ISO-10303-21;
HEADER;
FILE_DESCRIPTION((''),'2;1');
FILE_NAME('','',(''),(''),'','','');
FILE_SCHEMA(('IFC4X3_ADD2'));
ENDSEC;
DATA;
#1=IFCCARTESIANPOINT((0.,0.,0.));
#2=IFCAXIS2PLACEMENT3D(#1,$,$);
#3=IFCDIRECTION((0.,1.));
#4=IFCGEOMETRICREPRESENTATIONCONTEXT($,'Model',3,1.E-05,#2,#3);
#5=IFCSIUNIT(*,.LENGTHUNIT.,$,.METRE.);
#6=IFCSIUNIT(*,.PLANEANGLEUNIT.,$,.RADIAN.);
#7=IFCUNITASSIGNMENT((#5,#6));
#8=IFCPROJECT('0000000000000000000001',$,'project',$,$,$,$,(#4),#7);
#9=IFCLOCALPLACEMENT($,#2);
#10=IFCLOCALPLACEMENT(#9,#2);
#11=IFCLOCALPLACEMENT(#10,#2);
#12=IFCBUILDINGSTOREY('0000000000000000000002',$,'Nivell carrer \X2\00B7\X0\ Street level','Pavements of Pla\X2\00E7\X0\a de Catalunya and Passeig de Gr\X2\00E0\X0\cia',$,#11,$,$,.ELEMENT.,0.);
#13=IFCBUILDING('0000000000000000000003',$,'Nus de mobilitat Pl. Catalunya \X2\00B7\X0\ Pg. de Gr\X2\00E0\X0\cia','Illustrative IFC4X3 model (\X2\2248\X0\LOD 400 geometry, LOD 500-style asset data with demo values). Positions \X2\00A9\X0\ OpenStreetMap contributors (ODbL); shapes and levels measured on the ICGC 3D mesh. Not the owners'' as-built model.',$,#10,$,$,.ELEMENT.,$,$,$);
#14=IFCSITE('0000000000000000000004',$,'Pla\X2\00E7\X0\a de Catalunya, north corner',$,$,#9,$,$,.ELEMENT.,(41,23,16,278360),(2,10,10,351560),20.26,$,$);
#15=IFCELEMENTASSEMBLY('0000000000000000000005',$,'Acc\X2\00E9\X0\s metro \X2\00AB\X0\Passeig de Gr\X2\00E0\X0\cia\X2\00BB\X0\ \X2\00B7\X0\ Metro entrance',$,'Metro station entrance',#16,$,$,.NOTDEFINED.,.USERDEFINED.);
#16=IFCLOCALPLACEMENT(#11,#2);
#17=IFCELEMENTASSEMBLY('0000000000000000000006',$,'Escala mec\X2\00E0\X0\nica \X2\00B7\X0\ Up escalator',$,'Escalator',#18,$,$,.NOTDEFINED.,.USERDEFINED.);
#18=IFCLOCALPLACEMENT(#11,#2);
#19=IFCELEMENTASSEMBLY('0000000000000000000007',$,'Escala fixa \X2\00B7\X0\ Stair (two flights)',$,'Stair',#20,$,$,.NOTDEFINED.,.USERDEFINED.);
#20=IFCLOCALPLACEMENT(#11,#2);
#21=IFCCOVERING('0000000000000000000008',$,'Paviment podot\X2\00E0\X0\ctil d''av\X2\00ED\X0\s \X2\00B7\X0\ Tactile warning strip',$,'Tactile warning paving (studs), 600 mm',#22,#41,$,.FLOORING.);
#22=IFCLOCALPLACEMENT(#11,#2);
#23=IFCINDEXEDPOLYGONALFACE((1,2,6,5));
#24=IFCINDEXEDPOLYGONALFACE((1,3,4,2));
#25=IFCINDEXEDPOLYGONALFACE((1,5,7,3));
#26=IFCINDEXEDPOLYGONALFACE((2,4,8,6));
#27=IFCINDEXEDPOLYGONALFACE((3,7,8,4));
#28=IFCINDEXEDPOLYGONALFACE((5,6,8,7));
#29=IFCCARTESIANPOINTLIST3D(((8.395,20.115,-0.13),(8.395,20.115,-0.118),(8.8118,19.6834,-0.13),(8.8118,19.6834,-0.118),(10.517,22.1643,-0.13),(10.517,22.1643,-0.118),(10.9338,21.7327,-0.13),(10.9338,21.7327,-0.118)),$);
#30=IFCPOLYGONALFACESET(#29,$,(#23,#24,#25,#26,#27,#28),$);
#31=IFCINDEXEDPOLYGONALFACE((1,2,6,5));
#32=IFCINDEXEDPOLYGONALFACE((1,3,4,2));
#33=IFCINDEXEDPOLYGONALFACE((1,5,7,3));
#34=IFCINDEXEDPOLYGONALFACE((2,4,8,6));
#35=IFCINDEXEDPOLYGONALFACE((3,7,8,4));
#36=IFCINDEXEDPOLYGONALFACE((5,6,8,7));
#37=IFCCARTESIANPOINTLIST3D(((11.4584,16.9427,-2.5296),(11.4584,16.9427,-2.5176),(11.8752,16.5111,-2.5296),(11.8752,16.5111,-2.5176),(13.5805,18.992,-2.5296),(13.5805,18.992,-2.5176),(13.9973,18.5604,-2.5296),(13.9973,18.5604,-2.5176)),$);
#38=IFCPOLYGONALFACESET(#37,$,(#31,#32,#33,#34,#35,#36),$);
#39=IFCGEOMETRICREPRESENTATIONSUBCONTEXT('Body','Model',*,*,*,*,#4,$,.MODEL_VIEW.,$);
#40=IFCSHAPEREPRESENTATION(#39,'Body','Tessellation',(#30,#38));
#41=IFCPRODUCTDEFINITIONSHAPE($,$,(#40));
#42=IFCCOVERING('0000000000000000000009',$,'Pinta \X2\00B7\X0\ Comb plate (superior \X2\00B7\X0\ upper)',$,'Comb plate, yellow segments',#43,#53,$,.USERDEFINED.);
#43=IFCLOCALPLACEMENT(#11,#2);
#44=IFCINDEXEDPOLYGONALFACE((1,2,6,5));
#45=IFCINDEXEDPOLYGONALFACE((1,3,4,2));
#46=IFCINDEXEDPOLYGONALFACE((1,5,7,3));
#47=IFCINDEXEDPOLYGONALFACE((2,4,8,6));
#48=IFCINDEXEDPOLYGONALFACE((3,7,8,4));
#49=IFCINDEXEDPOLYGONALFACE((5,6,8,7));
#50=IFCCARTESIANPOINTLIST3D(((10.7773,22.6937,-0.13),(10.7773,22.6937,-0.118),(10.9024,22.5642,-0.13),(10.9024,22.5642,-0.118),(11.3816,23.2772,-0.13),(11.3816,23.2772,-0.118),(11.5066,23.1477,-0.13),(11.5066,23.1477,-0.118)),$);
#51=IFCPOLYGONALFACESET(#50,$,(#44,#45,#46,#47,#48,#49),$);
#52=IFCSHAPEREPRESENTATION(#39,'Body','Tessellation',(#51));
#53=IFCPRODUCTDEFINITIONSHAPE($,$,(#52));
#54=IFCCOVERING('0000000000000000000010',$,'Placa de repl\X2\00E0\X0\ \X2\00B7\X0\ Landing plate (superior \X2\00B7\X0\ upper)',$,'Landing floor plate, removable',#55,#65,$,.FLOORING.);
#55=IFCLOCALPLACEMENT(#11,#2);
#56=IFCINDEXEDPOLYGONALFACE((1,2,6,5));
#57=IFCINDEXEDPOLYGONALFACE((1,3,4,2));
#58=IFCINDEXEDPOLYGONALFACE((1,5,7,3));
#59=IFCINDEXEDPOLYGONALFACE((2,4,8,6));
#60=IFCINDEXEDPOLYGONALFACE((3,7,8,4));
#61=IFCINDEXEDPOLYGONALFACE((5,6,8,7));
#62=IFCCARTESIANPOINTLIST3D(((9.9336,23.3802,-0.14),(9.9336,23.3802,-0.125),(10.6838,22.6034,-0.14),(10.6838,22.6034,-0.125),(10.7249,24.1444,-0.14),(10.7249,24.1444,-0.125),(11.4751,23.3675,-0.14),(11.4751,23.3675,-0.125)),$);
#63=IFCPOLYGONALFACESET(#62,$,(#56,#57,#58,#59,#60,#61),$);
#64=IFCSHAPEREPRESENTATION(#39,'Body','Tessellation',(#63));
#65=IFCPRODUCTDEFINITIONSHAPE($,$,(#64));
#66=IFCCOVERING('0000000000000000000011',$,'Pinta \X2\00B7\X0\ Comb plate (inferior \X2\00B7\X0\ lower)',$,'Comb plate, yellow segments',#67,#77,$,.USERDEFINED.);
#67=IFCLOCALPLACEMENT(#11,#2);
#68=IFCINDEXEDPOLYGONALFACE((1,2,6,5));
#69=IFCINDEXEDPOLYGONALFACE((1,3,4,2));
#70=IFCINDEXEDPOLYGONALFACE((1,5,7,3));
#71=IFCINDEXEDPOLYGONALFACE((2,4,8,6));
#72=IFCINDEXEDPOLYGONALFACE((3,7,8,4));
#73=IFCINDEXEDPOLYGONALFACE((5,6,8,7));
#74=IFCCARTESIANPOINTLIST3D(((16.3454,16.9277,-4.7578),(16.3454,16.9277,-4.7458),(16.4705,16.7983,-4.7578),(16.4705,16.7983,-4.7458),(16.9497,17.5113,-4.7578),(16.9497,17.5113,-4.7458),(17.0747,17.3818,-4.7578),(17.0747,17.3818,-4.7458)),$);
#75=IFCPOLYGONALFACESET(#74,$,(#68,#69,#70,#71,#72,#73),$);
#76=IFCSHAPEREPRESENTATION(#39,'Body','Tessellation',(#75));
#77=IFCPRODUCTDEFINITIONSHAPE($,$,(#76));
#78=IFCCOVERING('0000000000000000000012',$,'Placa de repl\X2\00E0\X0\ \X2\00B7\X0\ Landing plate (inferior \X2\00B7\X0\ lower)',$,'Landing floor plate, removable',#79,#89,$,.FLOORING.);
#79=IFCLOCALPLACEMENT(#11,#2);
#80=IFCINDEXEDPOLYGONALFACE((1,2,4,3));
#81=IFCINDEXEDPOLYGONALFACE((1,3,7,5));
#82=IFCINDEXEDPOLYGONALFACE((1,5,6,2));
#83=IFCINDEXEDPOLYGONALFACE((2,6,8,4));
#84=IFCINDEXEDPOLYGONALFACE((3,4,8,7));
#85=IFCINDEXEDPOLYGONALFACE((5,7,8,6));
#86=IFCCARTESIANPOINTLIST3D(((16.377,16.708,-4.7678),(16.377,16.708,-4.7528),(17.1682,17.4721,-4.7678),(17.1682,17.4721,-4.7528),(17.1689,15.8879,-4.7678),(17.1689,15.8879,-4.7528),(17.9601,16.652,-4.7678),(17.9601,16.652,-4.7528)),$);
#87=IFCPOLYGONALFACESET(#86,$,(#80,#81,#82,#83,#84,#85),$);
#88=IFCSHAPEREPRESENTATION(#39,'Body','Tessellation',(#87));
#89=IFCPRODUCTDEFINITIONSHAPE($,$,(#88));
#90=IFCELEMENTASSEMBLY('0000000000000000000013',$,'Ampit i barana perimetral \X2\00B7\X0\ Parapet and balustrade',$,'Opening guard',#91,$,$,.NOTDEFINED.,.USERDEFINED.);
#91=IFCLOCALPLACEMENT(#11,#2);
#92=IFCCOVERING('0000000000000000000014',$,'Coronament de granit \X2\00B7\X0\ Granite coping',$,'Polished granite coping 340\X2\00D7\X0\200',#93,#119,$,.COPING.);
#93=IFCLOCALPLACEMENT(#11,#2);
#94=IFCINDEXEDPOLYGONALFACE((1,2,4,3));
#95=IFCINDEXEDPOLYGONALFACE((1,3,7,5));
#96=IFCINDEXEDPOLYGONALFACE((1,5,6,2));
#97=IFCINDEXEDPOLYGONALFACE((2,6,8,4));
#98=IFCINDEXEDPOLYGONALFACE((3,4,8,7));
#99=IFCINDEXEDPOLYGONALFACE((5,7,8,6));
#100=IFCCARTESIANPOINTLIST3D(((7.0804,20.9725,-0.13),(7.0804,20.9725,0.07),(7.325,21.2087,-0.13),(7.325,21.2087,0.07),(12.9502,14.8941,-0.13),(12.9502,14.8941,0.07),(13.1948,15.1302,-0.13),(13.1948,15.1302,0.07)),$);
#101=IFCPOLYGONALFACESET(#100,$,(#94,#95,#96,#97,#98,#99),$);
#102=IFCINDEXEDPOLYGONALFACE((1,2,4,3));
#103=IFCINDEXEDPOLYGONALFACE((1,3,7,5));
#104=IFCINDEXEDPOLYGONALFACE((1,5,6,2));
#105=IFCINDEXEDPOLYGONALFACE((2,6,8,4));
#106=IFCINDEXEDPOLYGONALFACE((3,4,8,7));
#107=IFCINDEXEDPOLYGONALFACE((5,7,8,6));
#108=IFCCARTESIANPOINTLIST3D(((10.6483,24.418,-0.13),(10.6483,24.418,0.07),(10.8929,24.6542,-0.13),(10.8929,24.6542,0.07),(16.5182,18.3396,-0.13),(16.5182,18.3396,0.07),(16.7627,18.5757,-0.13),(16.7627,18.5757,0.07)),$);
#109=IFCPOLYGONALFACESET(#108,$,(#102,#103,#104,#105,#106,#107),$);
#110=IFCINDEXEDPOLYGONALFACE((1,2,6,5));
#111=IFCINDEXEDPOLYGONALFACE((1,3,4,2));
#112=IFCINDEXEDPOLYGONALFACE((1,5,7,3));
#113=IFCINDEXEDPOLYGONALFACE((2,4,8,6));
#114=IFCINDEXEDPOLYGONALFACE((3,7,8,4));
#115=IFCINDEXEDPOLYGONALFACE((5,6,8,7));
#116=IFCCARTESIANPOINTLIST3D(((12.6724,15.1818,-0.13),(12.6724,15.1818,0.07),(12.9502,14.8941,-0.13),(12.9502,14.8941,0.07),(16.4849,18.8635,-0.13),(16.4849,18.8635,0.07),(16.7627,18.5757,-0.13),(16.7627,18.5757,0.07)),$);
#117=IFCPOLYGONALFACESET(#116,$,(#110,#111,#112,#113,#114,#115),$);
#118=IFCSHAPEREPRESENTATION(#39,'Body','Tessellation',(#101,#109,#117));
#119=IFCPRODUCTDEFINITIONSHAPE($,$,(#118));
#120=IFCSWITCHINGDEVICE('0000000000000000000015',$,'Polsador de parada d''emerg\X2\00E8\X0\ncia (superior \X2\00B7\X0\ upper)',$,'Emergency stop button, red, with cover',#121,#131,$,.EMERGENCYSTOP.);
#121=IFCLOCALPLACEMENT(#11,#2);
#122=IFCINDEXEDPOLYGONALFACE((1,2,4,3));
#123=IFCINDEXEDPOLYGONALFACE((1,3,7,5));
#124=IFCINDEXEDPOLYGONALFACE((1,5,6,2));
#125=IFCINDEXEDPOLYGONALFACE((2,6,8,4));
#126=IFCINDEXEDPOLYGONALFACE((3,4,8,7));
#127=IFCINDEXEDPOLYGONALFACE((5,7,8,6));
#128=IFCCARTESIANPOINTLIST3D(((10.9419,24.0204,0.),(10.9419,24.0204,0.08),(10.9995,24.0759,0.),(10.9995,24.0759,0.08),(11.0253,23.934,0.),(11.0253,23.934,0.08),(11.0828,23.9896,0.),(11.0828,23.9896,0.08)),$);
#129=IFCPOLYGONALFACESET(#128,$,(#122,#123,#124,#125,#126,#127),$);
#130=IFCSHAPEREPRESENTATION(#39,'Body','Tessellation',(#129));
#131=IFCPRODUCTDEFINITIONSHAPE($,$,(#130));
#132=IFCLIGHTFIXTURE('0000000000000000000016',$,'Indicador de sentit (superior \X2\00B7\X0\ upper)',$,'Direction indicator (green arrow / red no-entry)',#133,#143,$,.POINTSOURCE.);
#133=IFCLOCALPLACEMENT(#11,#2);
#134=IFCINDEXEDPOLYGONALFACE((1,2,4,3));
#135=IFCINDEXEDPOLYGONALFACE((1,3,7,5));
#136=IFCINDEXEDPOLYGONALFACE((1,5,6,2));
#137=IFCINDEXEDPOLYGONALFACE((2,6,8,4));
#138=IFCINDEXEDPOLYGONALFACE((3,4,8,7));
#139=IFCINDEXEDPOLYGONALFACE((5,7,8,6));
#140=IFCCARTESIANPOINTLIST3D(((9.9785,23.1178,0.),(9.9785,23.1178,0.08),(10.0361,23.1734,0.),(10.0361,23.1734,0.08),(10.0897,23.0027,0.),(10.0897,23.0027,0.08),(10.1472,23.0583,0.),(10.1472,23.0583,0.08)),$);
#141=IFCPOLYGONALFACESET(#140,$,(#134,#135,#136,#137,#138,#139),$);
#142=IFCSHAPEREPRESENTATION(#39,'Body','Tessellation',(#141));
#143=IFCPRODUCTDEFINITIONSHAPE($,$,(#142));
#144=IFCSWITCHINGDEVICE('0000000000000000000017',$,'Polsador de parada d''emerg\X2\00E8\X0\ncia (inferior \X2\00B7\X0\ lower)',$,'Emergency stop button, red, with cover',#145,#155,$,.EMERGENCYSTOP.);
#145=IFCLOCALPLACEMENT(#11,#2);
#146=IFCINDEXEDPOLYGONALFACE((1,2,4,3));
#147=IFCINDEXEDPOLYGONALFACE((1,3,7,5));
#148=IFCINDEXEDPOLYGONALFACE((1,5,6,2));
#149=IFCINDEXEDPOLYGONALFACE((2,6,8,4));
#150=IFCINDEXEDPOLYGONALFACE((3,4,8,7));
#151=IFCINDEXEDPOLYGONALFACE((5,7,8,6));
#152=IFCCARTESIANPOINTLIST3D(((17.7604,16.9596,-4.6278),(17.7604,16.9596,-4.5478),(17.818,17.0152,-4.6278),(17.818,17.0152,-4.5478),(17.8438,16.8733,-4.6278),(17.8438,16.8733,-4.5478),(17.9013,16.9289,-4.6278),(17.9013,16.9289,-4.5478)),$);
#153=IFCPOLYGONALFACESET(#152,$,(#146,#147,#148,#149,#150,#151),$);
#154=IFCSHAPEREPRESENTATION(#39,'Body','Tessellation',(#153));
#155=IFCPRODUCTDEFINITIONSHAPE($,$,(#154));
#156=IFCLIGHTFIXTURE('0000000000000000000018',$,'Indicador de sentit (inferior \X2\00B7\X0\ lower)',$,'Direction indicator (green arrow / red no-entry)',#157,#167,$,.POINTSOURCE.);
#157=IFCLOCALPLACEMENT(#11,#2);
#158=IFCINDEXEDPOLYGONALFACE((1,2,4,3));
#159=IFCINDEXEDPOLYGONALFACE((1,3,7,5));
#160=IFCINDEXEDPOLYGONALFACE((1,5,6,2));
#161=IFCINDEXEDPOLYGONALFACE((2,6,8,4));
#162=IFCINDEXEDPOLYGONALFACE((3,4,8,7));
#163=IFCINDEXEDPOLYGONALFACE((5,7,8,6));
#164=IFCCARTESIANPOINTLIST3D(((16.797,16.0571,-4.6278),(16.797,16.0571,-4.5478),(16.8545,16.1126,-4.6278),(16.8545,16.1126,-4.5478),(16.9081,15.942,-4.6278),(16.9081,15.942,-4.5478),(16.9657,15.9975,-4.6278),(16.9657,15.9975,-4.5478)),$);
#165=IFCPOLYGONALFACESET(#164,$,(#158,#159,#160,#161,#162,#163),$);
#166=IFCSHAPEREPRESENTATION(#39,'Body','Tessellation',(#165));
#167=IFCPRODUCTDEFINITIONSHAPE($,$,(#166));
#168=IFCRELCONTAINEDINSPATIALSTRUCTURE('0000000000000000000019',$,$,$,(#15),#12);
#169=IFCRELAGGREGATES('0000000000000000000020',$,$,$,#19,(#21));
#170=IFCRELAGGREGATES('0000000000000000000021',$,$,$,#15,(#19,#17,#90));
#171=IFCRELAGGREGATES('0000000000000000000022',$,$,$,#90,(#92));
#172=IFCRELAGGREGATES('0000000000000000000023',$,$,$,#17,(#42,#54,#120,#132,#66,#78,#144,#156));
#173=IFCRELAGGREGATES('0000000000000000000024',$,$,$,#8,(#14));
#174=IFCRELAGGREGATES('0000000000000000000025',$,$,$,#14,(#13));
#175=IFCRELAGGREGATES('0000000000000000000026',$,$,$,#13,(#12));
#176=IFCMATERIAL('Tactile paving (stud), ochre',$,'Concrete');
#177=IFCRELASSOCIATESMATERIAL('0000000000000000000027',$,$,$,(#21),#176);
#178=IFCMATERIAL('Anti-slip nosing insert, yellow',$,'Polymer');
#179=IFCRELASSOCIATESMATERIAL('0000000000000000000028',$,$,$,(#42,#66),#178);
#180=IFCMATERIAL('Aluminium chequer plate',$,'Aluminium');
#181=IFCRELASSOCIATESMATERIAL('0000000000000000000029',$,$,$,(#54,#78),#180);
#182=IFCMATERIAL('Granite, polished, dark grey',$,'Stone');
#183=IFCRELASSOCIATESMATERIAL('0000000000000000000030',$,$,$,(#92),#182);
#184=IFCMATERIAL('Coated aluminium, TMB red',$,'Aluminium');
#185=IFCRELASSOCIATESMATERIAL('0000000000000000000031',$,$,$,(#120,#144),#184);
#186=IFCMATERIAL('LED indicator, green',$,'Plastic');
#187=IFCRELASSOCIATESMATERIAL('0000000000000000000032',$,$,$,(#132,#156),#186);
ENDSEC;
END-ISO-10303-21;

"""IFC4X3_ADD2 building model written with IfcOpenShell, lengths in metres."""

from ifc_helpers import new_model, si_unit, direction, frame, frame_2d, origin, place, context, subcontext, project, spatial, rectangle, extrude, material, element, aggregate, save


model = new_model("IFC4X3_ADD2")

# Units and contexts
model_context = context("Model", 3, precision=1e-05, world=origin(), true_north=direction((0.0, 1.0)))
body_context = subcontext(model_context, "Body", "Model", "MODEL_VIEW")
ifc_project = project(units=[si_unit("LENGTHUNIT", "METRE"), si_unit("PLANEANGLEUNIT", "RADIAN")], contexts=[model_context])

# Site, building, storey
site_placement = place(None, origin())
site = spatial("IfcSite", under=ifc_project, at=site_placement, Name="Plaça de Catalunya, north corner", CompositionType="ELEMENT", RefLatitude=(41, 23, 16, 278360), RefLongitude=(2, 10, 10, 351560), RefElevation=20.26)
building_placement = place(site_placement, origin())
building = spatial("IfcBuilding", under=site, at=building_placement, Name="Nus de mobilitat Pl. Catalunya · Pg. de Gràcia", Description="Illustrative IFC4X3 model (≈LOD 400 geometry, LOD 500-style asset data with demo values). Positions © OpenStreetMap contributors (ODbL); shapes and levels measured on the ICGC 3D mesh. Not the owners' as-built model.", CompositionType="ELEMENT")
storey_placement = place(building_placement, origin())
storey = spatial("IfcBuildingStorey", under=building, at=storey_placement, Name="Nivell carrer · Street level", Description="Pavements of Plaça de Catalunya and Passeig de Gràcia", CompositionType="ELEMENT", Elevation=0.0)

# Element assemblies, coverings, switching devices, light fixtures
assembly_1_placement = place(building_placement, origin())
assembly_1 = element("IfcElementAssembly", 1, at=assembly_1_placement, inside=storey, Name="Accés metro «Passeig de Gràcia» · Metro entrance", ObjectType="Metro station entrance", AssemblyPlace="NOTDEFINED", PredefinedType="USERDEFINED")
assembly_2_placement = place(building_placement, origin())
assembly_2 = element("IfcElementAssembly", 2, at=assembly_2_placement, Name="Escala mecànica · Up escalator", ObjectType="Escalator", AssemblyPlace="NOTDEFINED", PredefinedType="USERDEFINED")
assembly_3_placement = place(building_placement, origin())
assembly_3 = element("IfcElementAssembly", 3, at=assembly_3_placement, Name="Escala fixa · Stair (two flights)", ObjectType="Stair", AssemblyPlace="NOTDEFINED", PredefinedType="USERDEFINED")
ifc_material_1 = material(Name="Anti-slip nosing insert, yellow", Category="Polymer")
ifc_material_2 = material(Name="Tactile paving (stud), ochre", Category="Concrete")
covering_1_placement = place(building_placement, origin())
covering_1 = element("IfcCovering", 4, at=covering_1_placement, material=ifc_material_2, Name="Paviment podotàctil d'avís · Tactile warning strip", ObjectType="Tactile warning paving (studs), 600 mm", PredefinedType="FLOORING", context=body_context, shape_type="SweptSolid", body=[
    extrude(rectangle(XDim=0.6, YDim=2.95, at=frame_2d((0.0, 0.0), x_axis=(0.694658, -0.71934))), frame((9.6644, 20.9238, -0.13)), (0.0, 0.0, 1.0), 0.012),
    extrude(rectangle(XDim=0.6, YDim=2.95, at=frame_2d((0.0, 0.0), x_axis=(0.694658, -0.71934))), frame((12.7278, 17.7516, -2.5296)), (0.0, 0.0, 1.0), 0.012),
])
aggregate(assembly_3, [covering_1])
covering_2_placement = place(building_placement, origin())
covering_2 = element("IfcCovering", 5, at=covering_2_placement, material=ifc_material_1, Name="Pinta · Comb plate (superior · upper)", ObjectType="Comb plate, yellow segments", PredefinedType="USERDEFINED", context=body_context, shape_type="SweptSolid", body=[
    extrude(rectangle(XDim=0.18, YDim=0.84, at=frame_2d((0.0, 0.0), x_axis=(0.694658, -0.71934))), frame((11.142, 22.9207, -0.13)), (0.0, 0.0, 1.0), 0.012),
])
ifc_material_3 = material(Name="Aluminium chequer plate", Category="Aluminium")
covering_3_placement = place(building_placement, origin())
covering_3 = element("IfcCovering", 6, at=covering_3_placement, material=ifc_material_3, Name="Placa de replà · Landing plate (superior · upper)", ObjectType="Landing floor plate, removable", PredefinedType="FLOORING", context=body_context, shape_type="SweptSolid", body=[
    extrude(rectangle(XDim=1.08, YDim=1.1, at=frame_2d((0.0, 0.0), x_axis=(0.694658, -0.71934))), frame((10.7043, 23.3739, -0.14)), (0.0, 0.0, 1.0), 0.015),
])
covering_4_placement = place(building_placement, origin())
covering_4 = element("IfcCovering", 7, at=covering_4_placement, material=ifc_material_1, Name="Pinta · Comb plate (inferior · lower)", ObjectType="Comb plate, yellow segments", PredefinedType="USERDEFINED", context=body_context, shape_type="SweptSolid", body=[
    extrude(rectangle(XDim=0.18, YDim=0.84, at=frame_2d((0.0, 0.0), x_axis=(0.694658, -0.71934))), frame((16.7101, 17.1548, -4.7578)), (0.0, 0.0, 1.0), 0.012),
])
covering_5_placement = place(building_placement, origin())
covering_5 = element("IfcCovering", 8, at=covering_5_placement, material=ifc_material_3, Name="Placa de replà · Landing plate (inferior · lower)", ObjectType="Landing floor plate, removable", PredefinedType="FLOORING", context=body_context, shape_type="SweptSolid", body=[
    extrude(rectangle(XDim=1.14, YDim=1.1, at=frame_2d((0.0, 0.0), x_axis=(0.694658, -0.71934))), frame((17.1685, 16.68, -4.7678)), (0.0, 0.0, 1.0), 0.015),
])
assembly_4_placement = place(building_placement, origin())
assembly_4 = element("IfcElementAssembly", 9, at=assembly_4_placement, Name="Ampit i barana perimetral · Parapet and balustrade", ObjectType="Opening guard", AssemblyPlace="NOTDEFINED", PredefinedType="USERDEFINED")
aggregate(assembly_1, [assembly_3, assembly_2, assembly_4])
ifc_material_4 = material(Name="Granite, polished, dark grey", Category="Stone")
covering_6_placement = place(building_placement, origin())
covering_6 = element("IfcCovering", 10, at=covering_6_placement, material=ifc_material_4, Name="Coronament de granit · Granite coping", ObjectType="Polished granite coping 340×200", PredefinedType="COPING", context=body_context, shape_type="SweptSolid", body=[
    extrude(rectangle(XDim=8.45, YDim=0.34, at=frame_2d((0.0, 0.0), x_axis=(0.694658, -0.71934))), frame((10.1376, 18.0514, -0.13)), (0.0, 0.0, 1.0), 0.2),
    extrude(rectangle(XDim=8.45, YDim=0.34, at=frame_2d((0.0, 0.0), x_axis=(0.694658, -0.71934))), frame((13.7055, 21.4969, -0.13)), (0.0, 0.0, 1.0), 0.2),
    extrude(rectangle(XDim=0.4, YDim=5.3, at=frame_2d((0.0, 0.0), x_axis=(0.694658, -0.71934))), frame((14.7176, 16.8788, -0.13)), (0.0, 0.0, 1.0), 0.2),
])
aggregate(assembly_4, [covering_6])
ifc_material_5 = material(Name="Coated aluminium, TMB red", Category="Aluminium")
switching_device_1_placement = place(building_placement, origin())
switching_device_1 = element("IfcSwitchingDevice", 11, at=switching_device_1_placement, material=ifc_material_5, Name="Polsador de parada d'emergència (superior · upper)", ObjectType="Emergency stop button, red, with cover", PredefinedType="EMERGENCYSTOP", context=body_context, shape_type="SweptSolid", body=[
    extrude(rectangle(XDim=0.12, YDim=0.08, at=frame_2d((0.0, 0.0), x_axis=(0.694658, -0.71934))), frame((11.0124, 24.005, 0.0)), (0.0, 0.0, 1.0), 0.08),
])
ifc_material_6 = material(Name="LED indicator, green", Category="Plastic")
light_fixture_1_placement = place(building_placement, origin())
light_fixture_1 = element("IfcLightFixture", 12, at=light_fixture_1_placement, material=ifc_material_6, Name="Indicador de sentit (superior · upper)", ObjectType="Direction indicator (green arrow / red no-entry)", PredefinedType="POINTSOURCE", context=body_context, shape_type="SweptSolid", body=[
    extrude(rectangle(XDim=0.16, YDim=0.08, at=frame_2d((0.0, 0.0), x_axis=(0.694658, -0.71934))), frame((10.0629, 23.088, 0.0)), (0.0, 0.0, 1.0), 0.08),
])
switching_device_2_placement = place(building_placement, origin())
switching_device_2 = element("IfcSwitchingDevice", 13, at=switching_device_2_placement, material=ifc_material_5, Name="Polsador de parada d'emergència (inferior · lower)", ObjectType="Emergency stop button, red, with cover", PredefinedType="EMERGENCYSTOP", context=body_context, shape_type="SweptSolid", body=[
    extrude(rectangle(XDim=0.12, YDim=0.08, at=frame_2d((0.0, 0.0), x_axis=(0.694658, -0.71934))), frame((17.8309, 16.9442, -4.6278)), (0.0, 0.0, 1.0), 0.08),
])
light_fixture_2_placement = place(building_placement, origin())
light_fixture_2 = element("IfcLightFixture", 14, at=light_fixture_2_placement, material=ifc_material_6, Name="Indicador de sentit (inferior · lower)", ObjectType="Direction indicator (green arrow / red no-entry)", PredefinedType="POINTSOURCE", context=body_context, shape_type="SweptSolid", body=[
    extrude(rectangle(XDim=0.16, YDim=0.08, at=frame_2d((0.0, 0.0), x_axis=(0.694658, -0.71934))), frame((16.8813, 16.0273, -4.6278)), (0.0, 0.0, 1.0), 0.08),
])
aggregate(assembly_2, [covering_2, covering_3, switching_device_1, light_fixture_1, covering_4, covering_5, switching_device_2, light_fixture_2])

save(model, "model.ifc")
